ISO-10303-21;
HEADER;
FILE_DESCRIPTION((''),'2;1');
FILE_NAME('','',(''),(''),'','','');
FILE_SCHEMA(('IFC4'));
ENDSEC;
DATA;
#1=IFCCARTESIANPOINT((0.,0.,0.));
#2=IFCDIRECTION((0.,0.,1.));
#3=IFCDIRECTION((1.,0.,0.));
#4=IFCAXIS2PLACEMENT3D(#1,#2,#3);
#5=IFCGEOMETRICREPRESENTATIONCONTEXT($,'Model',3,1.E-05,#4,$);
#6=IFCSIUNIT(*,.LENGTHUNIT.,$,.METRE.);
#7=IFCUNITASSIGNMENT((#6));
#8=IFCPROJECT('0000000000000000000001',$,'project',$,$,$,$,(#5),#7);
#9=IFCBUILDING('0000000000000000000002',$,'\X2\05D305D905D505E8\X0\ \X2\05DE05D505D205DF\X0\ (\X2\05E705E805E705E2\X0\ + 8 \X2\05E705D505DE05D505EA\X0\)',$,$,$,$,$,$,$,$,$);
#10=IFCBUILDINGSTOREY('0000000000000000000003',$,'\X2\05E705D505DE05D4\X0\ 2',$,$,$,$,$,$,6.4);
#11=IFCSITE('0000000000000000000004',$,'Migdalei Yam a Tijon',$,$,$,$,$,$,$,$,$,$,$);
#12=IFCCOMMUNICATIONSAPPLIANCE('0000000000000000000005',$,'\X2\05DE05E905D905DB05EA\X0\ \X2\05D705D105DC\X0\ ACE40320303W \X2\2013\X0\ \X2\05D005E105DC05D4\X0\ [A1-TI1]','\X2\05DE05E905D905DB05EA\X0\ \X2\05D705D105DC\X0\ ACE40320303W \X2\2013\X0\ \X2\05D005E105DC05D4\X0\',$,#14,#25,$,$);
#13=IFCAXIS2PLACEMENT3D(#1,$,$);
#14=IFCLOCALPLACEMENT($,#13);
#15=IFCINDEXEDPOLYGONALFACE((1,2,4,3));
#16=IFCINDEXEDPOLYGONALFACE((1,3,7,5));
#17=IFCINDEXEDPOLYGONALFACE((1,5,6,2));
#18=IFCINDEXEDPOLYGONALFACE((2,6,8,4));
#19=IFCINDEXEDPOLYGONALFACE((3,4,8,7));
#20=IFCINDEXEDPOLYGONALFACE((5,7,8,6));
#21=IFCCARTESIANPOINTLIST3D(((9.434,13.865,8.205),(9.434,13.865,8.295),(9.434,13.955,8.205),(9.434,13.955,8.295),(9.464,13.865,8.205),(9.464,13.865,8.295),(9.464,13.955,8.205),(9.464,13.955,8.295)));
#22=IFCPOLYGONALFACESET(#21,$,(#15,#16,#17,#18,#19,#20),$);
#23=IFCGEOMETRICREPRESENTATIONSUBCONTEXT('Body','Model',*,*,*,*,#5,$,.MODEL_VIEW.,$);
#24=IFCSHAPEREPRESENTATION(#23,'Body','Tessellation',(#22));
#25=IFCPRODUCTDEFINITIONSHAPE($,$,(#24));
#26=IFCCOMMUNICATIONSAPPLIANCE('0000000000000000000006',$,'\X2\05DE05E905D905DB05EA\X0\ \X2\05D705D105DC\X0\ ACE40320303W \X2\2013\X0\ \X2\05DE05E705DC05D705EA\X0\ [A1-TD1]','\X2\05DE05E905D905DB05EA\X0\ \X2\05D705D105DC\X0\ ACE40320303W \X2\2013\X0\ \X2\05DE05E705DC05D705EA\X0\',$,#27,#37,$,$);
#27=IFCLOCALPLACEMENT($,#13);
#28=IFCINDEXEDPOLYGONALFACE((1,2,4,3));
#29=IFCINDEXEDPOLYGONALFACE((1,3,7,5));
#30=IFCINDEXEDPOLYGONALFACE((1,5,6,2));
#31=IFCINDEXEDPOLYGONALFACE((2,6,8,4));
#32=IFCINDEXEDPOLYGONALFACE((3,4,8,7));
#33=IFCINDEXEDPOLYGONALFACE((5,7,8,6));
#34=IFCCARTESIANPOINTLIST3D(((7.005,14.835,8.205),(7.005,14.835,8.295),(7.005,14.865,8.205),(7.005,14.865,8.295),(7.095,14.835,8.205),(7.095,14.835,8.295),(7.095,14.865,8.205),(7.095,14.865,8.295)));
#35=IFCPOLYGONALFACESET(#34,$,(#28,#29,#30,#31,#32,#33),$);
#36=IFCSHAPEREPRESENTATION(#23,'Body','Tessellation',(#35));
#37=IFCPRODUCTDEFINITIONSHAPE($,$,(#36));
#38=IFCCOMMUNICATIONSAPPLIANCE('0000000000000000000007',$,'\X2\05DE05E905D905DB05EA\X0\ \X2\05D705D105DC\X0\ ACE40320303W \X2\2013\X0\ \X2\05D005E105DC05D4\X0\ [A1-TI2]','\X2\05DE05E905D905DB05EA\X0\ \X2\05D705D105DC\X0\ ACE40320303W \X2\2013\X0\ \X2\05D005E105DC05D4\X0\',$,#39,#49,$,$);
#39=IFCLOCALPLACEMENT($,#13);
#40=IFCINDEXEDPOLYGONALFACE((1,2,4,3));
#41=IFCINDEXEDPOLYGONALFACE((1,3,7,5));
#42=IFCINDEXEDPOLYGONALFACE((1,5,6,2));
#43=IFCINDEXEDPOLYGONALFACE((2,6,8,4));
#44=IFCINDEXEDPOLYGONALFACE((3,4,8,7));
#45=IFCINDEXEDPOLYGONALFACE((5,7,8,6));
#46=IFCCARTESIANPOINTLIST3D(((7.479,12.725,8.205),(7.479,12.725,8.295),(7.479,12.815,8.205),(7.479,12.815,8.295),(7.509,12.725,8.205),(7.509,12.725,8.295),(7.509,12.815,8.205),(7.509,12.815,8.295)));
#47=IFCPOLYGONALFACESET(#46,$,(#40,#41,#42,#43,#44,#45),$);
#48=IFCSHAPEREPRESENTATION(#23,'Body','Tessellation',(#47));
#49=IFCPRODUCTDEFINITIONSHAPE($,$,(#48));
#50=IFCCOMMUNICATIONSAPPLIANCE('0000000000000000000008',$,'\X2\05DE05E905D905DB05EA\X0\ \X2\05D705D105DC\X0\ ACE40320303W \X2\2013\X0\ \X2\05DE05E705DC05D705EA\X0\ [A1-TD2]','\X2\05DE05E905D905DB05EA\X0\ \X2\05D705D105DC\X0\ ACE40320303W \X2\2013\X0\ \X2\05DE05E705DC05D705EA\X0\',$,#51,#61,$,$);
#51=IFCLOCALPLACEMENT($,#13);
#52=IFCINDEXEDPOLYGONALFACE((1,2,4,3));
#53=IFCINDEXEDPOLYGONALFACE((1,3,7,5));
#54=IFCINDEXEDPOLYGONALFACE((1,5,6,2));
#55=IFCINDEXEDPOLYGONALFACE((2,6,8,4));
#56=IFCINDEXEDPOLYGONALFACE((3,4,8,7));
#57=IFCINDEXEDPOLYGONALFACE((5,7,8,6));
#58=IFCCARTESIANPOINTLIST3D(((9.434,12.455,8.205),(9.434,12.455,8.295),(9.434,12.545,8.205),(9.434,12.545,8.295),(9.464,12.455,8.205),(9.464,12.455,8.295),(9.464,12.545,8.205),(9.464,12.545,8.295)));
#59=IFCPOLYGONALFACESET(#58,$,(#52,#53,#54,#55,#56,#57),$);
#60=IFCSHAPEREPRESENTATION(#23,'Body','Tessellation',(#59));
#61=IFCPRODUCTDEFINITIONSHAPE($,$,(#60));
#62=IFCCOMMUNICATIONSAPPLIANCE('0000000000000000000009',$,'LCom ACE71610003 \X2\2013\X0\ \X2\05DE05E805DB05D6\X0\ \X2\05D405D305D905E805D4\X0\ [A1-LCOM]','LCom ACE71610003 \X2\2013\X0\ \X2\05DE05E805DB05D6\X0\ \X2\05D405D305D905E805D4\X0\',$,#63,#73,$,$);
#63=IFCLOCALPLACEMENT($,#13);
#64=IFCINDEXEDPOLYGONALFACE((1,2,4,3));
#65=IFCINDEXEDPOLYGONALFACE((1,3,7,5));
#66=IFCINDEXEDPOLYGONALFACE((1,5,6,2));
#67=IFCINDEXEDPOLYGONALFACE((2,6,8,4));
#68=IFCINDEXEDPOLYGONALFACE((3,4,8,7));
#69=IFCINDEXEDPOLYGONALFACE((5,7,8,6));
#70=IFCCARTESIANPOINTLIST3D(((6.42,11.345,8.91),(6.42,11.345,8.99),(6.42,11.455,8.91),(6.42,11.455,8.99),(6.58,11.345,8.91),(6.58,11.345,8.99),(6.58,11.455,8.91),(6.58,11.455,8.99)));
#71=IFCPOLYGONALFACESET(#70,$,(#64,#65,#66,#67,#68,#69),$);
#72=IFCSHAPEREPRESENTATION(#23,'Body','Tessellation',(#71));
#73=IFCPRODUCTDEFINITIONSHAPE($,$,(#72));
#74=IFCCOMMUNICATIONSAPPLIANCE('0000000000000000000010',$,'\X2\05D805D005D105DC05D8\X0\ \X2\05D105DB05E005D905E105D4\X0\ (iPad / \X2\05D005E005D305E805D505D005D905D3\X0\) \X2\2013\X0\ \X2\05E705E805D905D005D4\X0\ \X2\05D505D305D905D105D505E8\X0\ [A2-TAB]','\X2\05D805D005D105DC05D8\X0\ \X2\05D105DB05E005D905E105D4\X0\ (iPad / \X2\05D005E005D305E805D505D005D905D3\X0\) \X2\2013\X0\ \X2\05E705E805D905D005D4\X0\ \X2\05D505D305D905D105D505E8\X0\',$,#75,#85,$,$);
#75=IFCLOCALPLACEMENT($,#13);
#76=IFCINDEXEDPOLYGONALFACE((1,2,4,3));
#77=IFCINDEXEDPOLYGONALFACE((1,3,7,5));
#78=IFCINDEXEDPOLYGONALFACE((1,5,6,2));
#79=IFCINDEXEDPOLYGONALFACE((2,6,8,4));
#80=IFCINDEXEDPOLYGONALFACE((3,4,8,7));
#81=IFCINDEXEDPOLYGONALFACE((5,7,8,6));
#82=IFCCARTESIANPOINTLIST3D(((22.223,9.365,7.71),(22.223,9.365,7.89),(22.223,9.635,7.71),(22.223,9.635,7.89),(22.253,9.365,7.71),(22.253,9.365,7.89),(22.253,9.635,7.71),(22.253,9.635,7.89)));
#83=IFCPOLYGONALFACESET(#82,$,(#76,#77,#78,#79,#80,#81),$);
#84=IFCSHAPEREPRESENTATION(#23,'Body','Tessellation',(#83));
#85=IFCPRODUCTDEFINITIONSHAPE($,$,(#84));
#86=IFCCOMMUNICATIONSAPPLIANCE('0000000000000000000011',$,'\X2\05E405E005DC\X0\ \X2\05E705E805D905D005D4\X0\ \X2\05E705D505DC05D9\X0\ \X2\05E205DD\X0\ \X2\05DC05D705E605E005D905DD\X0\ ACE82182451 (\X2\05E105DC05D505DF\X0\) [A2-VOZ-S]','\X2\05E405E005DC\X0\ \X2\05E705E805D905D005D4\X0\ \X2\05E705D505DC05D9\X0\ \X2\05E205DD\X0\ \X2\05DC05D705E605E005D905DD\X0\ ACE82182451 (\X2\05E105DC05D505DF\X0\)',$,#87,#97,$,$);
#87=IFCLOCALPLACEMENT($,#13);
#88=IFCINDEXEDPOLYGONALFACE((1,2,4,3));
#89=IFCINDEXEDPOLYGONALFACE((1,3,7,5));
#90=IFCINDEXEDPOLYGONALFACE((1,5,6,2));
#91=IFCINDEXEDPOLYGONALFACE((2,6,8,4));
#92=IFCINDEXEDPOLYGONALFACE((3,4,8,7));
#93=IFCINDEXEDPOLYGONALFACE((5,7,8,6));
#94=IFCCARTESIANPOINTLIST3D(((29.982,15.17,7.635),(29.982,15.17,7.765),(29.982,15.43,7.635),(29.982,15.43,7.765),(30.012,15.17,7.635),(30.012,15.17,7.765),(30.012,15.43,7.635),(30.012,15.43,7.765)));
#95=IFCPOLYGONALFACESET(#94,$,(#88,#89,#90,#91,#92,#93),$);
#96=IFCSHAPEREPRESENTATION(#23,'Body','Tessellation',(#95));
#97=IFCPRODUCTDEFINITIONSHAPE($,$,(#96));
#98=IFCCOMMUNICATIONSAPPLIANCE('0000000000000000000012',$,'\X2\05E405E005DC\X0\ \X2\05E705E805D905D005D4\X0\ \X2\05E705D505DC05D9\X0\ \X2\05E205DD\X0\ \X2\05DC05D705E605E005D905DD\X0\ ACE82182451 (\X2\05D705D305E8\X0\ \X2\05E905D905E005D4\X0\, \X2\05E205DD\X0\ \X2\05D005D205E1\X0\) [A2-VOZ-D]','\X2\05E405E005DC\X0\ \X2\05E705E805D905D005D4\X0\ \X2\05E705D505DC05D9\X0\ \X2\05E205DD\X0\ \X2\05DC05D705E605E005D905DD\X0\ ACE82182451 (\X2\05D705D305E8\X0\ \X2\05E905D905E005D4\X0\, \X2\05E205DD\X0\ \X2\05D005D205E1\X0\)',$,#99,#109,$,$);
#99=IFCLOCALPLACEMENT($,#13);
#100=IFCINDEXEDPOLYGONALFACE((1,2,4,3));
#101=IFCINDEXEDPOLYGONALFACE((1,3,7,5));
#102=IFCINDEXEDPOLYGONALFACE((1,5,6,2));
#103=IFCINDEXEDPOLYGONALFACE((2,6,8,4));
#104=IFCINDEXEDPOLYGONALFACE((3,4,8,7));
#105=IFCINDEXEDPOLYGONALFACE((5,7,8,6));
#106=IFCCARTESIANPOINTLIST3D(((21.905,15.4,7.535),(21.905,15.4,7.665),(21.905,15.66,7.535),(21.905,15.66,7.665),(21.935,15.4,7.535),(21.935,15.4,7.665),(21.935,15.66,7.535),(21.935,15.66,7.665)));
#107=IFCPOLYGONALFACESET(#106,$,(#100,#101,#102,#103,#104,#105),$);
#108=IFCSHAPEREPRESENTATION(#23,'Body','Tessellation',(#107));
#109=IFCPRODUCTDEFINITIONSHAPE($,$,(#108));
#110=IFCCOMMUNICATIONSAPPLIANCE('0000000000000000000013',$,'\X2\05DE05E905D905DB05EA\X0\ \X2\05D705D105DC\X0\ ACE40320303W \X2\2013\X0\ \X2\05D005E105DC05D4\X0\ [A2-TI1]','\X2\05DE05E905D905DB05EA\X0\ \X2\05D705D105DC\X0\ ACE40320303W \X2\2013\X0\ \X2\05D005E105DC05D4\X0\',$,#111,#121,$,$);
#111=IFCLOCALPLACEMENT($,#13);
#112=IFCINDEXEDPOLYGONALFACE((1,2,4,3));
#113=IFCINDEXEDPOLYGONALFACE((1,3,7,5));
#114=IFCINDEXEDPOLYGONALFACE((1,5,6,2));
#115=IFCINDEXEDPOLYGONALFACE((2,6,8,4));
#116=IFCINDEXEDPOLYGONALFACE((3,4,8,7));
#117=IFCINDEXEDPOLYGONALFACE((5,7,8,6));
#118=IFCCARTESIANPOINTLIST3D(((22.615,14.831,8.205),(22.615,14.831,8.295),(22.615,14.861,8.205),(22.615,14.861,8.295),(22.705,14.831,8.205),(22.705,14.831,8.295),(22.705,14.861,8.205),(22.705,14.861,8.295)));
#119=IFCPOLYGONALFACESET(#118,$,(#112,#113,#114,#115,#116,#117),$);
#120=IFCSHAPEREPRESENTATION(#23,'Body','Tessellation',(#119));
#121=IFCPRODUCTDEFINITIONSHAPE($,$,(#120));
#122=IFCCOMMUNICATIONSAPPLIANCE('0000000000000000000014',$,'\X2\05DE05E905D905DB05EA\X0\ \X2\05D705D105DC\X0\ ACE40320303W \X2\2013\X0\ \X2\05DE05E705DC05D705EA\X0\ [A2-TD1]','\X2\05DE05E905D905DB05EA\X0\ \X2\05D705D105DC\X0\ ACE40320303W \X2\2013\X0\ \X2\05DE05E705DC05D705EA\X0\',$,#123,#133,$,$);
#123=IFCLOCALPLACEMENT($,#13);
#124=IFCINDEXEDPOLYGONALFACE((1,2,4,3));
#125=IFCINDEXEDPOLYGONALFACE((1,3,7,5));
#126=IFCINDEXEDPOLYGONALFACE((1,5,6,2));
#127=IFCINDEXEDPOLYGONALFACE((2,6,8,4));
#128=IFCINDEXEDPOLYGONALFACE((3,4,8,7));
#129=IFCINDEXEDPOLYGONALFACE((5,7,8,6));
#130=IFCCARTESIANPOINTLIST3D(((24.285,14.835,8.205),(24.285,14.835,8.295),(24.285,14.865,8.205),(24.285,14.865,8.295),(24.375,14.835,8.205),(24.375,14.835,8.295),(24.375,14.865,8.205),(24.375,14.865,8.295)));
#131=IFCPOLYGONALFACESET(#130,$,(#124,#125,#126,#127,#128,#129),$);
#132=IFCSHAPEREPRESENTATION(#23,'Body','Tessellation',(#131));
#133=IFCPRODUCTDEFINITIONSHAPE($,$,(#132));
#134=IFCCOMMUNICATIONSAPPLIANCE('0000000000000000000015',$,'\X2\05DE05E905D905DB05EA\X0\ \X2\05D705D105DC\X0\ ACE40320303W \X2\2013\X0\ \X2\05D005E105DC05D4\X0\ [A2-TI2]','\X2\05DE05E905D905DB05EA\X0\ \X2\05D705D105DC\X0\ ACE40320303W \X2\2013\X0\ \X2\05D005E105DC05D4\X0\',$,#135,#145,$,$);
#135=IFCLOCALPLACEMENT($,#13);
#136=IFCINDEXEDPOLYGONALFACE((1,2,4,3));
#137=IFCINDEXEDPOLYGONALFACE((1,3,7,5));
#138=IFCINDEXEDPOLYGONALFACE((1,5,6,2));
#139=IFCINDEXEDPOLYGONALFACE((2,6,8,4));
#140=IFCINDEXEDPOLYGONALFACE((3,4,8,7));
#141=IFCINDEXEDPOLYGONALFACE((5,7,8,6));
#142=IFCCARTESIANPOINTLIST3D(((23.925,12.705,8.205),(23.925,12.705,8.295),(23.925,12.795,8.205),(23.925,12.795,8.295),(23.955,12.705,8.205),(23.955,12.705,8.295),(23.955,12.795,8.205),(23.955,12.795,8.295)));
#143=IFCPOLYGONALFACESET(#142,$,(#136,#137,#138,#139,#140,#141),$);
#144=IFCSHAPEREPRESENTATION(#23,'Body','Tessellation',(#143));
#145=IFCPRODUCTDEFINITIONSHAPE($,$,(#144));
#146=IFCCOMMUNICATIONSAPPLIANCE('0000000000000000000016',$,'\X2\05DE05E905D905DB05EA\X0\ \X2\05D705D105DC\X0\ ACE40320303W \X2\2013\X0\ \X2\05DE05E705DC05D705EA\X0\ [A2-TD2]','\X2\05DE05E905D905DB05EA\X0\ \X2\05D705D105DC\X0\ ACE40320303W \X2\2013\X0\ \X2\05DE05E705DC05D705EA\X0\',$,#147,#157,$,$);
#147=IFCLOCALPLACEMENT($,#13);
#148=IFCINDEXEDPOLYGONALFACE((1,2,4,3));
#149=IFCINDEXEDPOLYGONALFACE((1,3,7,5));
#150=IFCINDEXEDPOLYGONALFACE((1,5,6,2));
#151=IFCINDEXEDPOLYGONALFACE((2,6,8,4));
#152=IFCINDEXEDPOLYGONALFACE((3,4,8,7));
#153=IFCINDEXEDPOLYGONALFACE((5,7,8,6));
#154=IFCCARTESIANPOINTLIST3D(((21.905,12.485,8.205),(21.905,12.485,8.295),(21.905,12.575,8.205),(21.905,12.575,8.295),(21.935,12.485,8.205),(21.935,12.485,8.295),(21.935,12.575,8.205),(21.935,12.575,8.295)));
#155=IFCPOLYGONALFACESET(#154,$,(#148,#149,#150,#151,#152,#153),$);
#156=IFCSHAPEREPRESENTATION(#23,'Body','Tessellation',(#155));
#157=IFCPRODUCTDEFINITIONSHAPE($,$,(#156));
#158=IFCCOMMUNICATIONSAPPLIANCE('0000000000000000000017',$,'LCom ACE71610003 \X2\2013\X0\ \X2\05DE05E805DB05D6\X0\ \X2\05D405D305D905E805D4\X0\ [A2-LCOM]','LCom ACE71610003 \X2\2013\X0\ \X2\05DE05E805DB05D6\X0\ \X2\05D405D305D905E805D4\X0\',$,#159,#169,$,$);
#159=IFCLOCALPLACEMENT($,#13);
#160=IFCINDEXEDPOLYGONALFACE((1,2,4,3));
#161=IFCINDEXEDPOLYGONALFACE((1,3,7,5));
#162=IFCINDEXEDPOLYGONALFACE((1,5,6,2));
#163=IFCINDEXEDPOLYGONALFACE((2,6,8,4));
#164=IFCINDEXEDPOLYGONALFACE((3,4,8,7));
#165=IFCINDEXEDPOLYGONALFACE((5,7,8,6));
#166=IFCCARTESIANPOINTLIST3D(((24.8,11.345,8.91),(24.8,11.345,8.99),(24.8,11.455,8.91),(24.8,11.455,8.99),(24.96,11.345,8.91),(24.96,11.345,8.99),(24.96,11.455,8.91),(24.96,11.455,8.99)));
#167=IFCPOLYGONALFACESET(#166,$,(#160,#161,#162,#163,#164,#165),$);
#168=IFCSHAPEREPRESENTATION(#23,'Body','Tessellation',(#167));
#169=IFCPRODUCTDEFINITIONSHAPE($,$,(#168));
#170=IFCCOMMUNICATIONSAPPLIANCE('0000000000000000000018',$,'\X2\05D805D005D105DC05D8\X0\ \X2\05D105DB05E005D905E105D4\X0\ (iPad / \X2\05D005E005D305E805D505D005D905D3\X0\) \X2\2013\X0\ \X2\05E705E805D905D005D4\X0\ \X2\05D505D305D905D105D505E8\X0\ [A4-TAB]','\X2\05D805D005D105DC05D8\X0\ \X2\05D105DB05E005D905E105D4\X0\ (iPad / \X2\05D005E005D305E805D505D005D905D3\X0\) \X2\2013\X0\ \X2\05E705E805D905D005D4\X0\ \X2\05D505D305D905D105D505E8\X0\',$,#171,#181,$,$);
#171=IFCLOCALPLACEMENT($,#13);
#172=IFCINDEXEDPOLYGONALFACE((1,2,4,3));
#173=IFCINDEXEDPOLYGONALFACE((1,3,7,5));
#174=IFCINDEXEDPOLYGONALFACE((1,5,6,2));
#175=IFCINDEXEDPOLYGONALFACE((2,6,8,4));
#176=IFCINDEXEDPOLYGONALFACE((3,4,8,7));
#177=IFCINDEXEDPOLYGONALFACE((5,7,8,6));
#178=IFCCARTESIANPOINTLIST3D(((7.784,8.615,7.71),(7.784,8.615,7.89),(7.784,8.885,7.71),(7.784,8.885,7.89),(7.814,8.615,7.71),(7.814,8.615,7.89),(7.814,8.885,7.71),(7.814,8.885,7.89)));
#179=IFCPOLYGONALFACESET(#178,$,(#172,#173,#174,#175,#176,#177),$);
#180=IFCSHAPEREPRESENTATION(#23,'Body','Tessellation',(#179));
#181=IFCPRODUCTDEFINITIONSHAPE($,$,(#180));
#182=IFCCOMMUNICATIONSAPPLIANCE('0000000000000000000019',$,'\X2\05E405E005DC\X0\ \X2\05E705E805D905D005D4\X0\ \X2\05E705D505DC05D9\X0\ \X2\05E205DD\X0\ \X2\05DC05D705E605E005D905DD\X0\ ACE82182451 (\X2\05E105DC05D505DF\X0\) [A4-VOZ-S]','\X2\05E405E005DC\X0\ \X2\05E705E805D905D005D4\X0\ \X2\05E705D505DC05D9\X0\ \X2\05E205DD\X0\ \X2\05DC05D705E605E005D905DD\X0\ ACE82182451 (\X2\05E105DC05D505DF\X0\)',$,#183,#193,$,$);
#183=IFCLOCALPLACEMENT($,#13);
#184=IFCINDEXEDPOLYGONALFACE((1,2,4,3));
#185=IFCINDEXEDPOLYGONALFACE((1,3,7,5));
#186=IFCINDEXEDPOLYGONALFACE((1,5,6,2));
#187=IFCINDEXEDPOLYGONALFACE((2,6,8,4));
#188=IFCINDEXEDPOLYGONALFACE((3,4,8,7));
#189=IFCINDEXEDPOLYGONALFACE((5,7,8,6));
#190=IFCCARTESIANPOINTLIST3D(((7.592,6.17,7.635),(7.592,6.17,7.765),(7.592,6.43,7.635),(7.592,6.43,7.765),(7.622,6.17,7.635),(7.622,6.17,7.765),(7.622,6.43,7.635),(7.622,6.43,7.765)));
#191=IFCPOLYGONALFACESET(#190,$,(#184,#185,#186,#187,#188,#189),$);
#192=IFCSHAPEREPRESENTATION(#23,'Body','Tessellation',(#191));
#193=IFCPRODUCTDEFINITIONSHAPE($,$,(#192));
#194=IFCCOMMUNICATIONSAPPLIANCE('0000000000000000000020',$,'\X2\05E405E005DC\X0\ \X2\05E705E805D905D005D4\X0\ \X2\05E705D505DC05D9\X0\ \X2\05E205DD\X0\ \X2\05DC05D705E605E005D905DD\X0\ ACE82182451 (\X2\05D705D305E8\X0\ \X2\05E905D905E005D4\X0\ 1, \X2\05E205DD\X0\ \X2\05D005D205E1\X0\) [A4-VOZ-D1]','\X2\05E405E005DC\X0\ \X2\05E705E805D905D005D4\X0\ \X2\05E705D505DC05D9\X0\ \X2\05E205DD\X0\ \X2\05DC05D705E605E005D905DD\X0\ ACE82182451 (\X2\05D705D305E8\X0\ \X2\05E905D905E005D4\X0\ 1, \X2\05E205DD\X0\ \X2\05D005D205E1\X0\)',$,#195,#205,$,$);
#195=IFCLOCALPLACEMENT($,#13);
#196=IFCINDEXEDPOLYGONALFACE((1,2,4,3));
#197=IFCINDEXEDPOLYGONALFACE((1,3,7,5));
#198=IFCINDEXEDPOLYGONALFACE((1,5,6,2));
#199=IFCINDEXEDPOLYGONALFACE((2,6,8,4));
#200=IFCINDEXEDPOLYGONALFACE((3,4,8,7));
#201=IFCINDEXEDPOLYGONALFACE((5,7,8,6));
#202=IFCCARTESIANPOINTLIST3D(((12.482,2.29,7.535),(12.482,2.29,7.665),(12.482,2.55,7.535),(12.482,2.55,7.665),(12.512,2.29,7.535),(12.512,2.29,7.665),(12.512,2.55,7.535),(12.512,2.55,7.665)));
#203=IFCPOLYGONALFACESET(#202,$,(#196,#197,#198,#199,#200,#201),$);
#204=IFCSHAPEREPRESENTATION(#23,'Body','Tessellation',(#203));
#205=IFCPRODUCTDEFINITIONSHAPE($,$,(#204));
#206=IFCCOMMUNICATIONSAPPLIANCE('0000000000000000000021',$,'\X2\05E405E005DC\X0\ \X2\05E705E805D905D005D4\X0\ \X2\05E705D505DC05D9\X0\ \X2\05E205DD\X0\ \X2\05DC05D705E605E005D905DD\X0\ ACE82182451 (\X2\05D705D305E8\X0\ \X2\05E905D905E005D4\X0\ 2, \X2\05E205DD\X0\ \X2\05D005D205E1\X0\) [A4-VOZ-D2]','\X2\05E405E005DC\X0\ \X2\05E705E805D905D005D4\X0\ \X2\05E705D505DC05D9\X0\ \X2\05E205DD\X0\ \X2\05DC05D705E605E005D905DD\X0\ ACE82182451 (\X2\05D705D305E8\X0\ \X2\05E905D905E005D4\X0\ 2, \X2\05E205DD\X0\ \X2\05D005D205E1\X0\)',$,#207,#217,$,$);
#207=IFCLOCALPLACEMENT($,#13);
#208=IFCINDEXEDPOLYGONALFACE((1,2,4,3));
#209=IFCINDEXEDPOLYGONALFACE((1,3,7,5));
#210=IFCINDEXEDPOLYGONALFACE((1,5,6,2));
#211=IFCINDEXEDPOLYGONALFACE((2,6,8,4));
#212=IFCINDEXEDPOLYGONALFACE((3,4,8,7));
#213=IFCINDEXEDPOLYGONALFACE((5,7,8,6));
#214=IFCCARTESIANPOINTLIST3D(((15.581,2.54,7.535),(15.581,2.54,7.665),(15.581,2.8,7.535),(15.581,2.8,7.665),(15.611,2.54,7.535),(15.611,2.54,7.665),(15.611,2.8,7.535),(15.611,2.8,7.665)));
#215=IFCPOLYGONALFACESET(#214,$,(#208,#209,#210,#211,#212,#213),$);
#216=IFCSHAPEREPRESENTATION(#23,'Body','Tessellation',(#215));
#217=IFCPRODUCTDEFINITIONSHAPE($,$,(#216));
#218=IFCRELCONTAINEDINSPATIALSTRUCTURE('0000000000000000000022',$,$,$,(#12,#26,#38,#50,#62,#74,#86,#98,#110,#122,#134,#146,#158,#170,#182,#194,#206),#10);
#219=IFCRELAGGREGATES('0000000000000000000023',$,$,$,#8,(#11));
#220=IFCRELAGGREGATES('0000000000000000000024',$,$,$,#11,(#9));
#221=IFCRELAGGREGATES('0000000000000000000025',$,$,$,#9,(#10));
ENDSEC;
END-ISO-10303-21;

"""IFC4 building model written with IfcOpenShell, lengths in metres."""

from ifc_helpers import new_model, si_unit, frame, origin_with_axes, context, subcontext, project, spatial, line, indexed_curve, outline, extrude, element, save


model = new_model("IFC4")

# Units and contexts
model_context = context("Model", 3, precision=1e-05, world=origin_with_axes())
body_context = subcontext(model_context, "Body", "Model", "MODEL_VIEW")
ifc_project = project(units=[si_unit("LENGTHUNIT", "METRE")], contexts=[model_context])

# Site, building, storey
site = spatial("IfcSite", under=ifc_project, Name="Migdalei Yam a Tijon")
building = spatial("IfcBuilding", under=site, Name="דיור מוגן (קרקע + 8 קומות)")
storey = spatial("IfcBuildingStorey", under=building, Name="קומה 2", Elevation=6.4)

# Communications appliances
element("IfcCommunicationsAppliance", 1, inside=storey, Name="משיכת חבל ACE40320303W – אסלה [A1-TI1]", Description="משיכת חבל ACE40320303W – אסלה", context=body_context, shape_type="SweptSolid", body=[
    extrude(outline(indexed_curve([(0.0, 0.0), (0.03, 0.0), (0.03, 0.09), (0.0, 0.09)], segments=[line(1, 2, 3, 4, 1)])), frame((9.434, 13.865, 8.205), z_axis=(0.0, 0.0, 1.0), x_axis=(1.0, 0.0, 0.0)), (0.0, 0.0, 1.0), 0.09),
])
element("IfcCommunicationsAppliance", 2, inside=storey, Name="משיכת חבל ACE40320303W – מקלחת [A1-TD1]", Description="משיכת חבל ACE40320303W – מקלחת", context=body_context, shape_type="SweptSolid", body=[
    extrude(outline(indexed_curve([(0.0, 0.0), (0.09, 0.0), (0.09, 0.03), (0.0, 0.03)], segments=[line(1, 2, 3, 4, 1)])), frame((7.005, 14.835, 8.205), z_axis=(0.0, 0.0, 1.0), x_axis=(1.0, 0.0, 0.0)), (0.0, 0.0, 1.0), 0.09),
])
element("IfcCommunicationsAppliance", 3, inside=storey, Name="משיכת חבל ACE40320303W – אסלה [A1-TI2]", Description="משיכת חבל ACE40320303W – אסלה", context=body_context, shape_type="SweptSolid", body=[
    extrude(outline(indexed_curve([(0.0, 0.0), (0.03, 0.0), (0.03, 0.09), (0.0, 0.09)], segments=[line(1, 2, 3, 4, 1)])), frame((7.479, 12.725, 8.205), z_axis=(0.0, 0.0, 1.0), x_axis=(1.0, 0.0, 0.0)), (0.0, 0.0, 1.0), 0.09),
])
element("IfcCommunicationsAppliance", 4, inside=storey, Name="משיכת חבל ACE40320303W – מקלחת [A1-TD2]", Description="משיכת חבל ACE40320303W – מקלחת", context=body_context, shape_type="SweptSolid", body=[
    extrude(outline(indexed_curve([(0.0, 0.0), (0.03, 0.0), (0.03, 0.09), (0.0, 0.09)], segments=[line(1, 2, 3, 4, 1)])), frame((9.434, 12.455, 8.205), z_axis=(0.0, 0.0, 1.0), x_axis=(1.0, 0.0, 0.0)), (0.0, 0.0, 1.0), 0.09),
])
element("IfcCommunicationsAppliance", 5, inside=storey, Name="LCom ACE71610003 – מרכז הדירה [A1-LCOM]", Description="LCom ACE71610003 – מרכז הדירה", context=body_context, shape_type="SweptSolid", body=[
    extrude(outline(indexed_curve([(0.0, 0.0), (0.16, 0.0), (0.16, 0.11), (0.0, 0.11)], segments=[line(1, 2, 3, 4, 1)])), frame((6.42, 11.345, 8.91), z_axis=(0.0, 0.0, 1.0), x_axis=(1.0, 0.0, 0.0)), (0.0, 0.0, 1.0), 0.08),
])
element("IfcCommunicationsAppliance", 6, inside=storey, Name="טאבלט בכניסה (iPad / אנדרואיד) – קריאה ודיבור [A2-TAB]", Description="טאבלט בכניסה (iPad / אנדרואיד) – קריאה ודיבור", context=body_context, shape_type="SweptSolid", body=[
    extrude(outline(indexed_curve([(0.0, 0.0), (0.03, 0.0), (0.03, 0.27), (0.0, 0.27)], segments=[line(1, 2, 3, 4, 1)])), frame((22.223, 9.365, 7.71), z_axis=(0.0, 0.0, 1.0), x_axis=(1.0, 0.0, 0.0)), (0.0, 0.0, 1.0), 0.18),
])
element("IfcCommunicationsAppliance", 7, inside=storey, Name="פנל קריאה קולי עם לחצנים ACE82182451 (סלון) [A2-VOZ-S]", Description="פנל קריאה קולי עם לחצנים ACE82182451 (סלון)", context=body_context, shape_type="SweptSolid", body=[
    extrude(outline(indexed_curve([(0.0, 0.0), (0.03, 0.0), (0.03, 0.26), (0.0, 0.26)], segments=[line(1, 2, 3, 4, 1)])), frame((29.982, 15.17, 7.635), z_axis=(0.0, 0.0, 1.0), x_axis=(1.0, 0.0, 0.0)), (0.0, 0.0, 1.0), 0.13),
])
element("IfcCommunicationsAppliance", 8, inside=storey, Name="פנל קריאה קולי עם לחצנים ACE82182451 (חדר שינה, עם אגס) [A2-VOZ-D]", Description="פנל קריאה קולי עם לחצנים ACE82182451 (חדר שינה, עם אגס)", context=body_context, shape_type="SweptSolid", body=[
    extrude(outline(indexed_curve([(0.0, 0.0), (0.03, 0.0), (0.03, 0.26), (0.0, 0.26)], segments=[line(1, 2, 3, 4, 1)])), frame((21.905, 15.4, 7.535), z_axis=(0.0, 0.0, 1.0), x_axis=(1.0, 0.0, 0.0)), (0.0, 0.0, 1.0), 0.13),
])
element("IfcCommunicationsAppliance", 9, inside=storey, Name="משיכת חבל ACE40320303W – אסלה [A2-TI1]", Description="משיכת חבל ACE40320303W – אסלה", context=body_context, shape_type="SweptSolid", body=[
    extrude(outline(indexed_curve([(0.0, 0.0), (0.09, 0.0), (0.09, 0.03), (0.0, 0.03)], segments=[line(1, 2, 3, 4, 1)])), frame((22.615, 14.831, 8.205), z_axis=(0.0, 0.0, 1.0), x_axis=(1.0, 0.0, 0.0)), (0.0, 0.0, 1.0), 0.09),
])
element("IfcCommunicationsAppliance", 10, inside=storey, Name="משיכת חבל ACE40320303W – מקלחת [A2-TD1]", Description="משיכת חבל ACE40320303W – מקלחת", context=body_context, shape_type="SweptSolid", body=[
    extrude(outline(indexed_curve([(0.0, 0.0), (0.09, 0.0), (0.09, 0.03), (0.0, 0.03)], segments=[line(1, 2, 3, 4, 1)])), frame((24.285, 14.835, 8.205), z_axis=(0.0, 0.0, 1.0), x_axis=(1.0, 0.0, 0.0)), (0.0, 0.0, 1.0), 0.09),
])
element("IfcCommunicationsAppliance", 11, inside=storey, Name="משיכת חבל ACE40320303W – אסלה [A2-TI2]", Description="משיכת חבל ACE40320303W – אסלה", context=body_context, shape_type="SweptSolid", body=[
    extrude(outline(indexed_curve([(0.0, 0.0), (0.03, 0.0), (0.03, 0.09), (0.0, 0.09)], segments=[line(1, 2, 3, 4, 1)])), frame((23.925, 12.705, 8.205), z_axis=(0.0, 0.0, 1.0), x_axis=(1.0, 0.0, 0.0)), (0.0, 0.0, 1.0), 0.09),
])
element("IfcCommunicationsAppliance", 12, inside=storey, Name="משיכת חבל ACE40320303W – מקלחת [A2-TD2]", Description="משיכת חבל ACE40320303W – מקלחת", context=body_context, shape_type="SweptSolid", body=[
    extrude(outline(indexed_curve([(0.0, 0.0), (0.03, 0.0), (0.03, 0.09), (0.0, 0.09)], segments=[line(1, 2, 3, 4, 1)])), frame((21.905, 12.485, 8.205), z_axis=(0.0, 0.0, 1.0), x_axis=(1.0, 0.0, 0.0)), (0.0, 0.0, 1.0), 0.09),
])
element("IfcCommunicationsAppliance", 13, inside=storey, Name="LCom ACE71610003 – מרכז הדירה [A2-LCOM]", Description="LCom ACE71610003 – מרכז הדירה", context=body_context, shape_type="SweptSolid", body=[
    extrude(outline(indexed_curve([(0.0, 0.0), (0.16, 0.0), (0.16, 0.11), (0.0, 0.11)], segments=[line(1, 2, 3, 4, 1)])), frame((24.8, 11.345, 8.91), z_axis=(0.0, 0.0, 1.0), x_axis=(1.0, 0.0, 0.0)), (0.0, 0.0, 1.0), 0.08),
])
element("IfcCommunicationsAppliance", 14, inside=storey, Name="טאבלט בכניסה (iPad / אנדרואיד) – קריאה ודיבור [A4-TAB]", Description="טאבלט בכניסה (iPad / אנדרואיד) – קריאה ודיבור", context=body_context, shape_type="SweptSolid", body=[
    extrude(outline(indexed_curve([(0.0, 0.0), (0.03, 0.0), (0.03, 0.27), (0.0, 0.27)], segments=[line(1, 2, 3, 4, 1)])), frame((7.784, 8.615, 7.71), z_axis=(0.0, 0.0, 1.0), x_axis=(1.0, 0.0, 0.0)), (0.0, 0.0, 1.0), 0.18),
])
element("IfcCommunicationsAppliance", 15, inside=storey, Name="פנל קריאה קולי עם לחצנים ACE82182451 (סלון) [A4-VOZ-S]", Description="פנל קריאה קולי עם לחצנים ACE82182451 (סלון)", context=body_context, shape_type="SweptSolid", body=[
    extrude(outline(indexed_curve([(0.0, 0.0), (0.03, 0.0), (0.03, 0.26), (0.0, 0.26)], segments=[line(1, 2, 3, 4, 1)])), frame((7.592, 6.17, 7.635), z_axis=(0.0, 0.0, 1.0), x_axis=(1.0, 0.0, 0.0)), (0.0, 0.0, 1.0), 0.13),
])
element("IfcCommunicationsAppliance", 16, inside=storey, Name="פנל קריאה קולי עם לחצנים ACE82182451 (חדר שינה 1, עם אגס) [A4-VOZ-D1]", Description="פנל קריאה קולי עם לחצנים ACE82182451 (חדר שינה 1, עם אגס)", context=body_context, shape_type="SweptSolid", body=[
    extrude(outline(indexed_curve([(0.0, 0.0), (0.03, 0.0), (0.03, 0.26), (0.0, 0.26)], segments=[line(1, 2, 3, 4, 1)])), frame((12.482, 2.29, 7.535), z_axis=(0.0, 0.0, 1.0), x_axis=(1.0, 0.0, 0.0)), (0.0, 0.0, 1.0), 0.13),
])
element("IfcCommunicationsAppliance", 17, inside=storey, Name="פנל קריאה קולי עם לחצנים ACE82182451 (חדר שינה 2, עם אגס) [A4-VOZ-D2]", Description="פנל קריאה קולי עם לחצנים ACE82182451 (חדר שינה 2, עם אגס)", context=body_context, shape_type="SweptSolid", body=[
    extrude(outline(indexed_curve([(0.0, 0.0), (0.03, 0.0), (0.03, 0.26), (0.0, 0.26)], segments=[line(1, 2, 3, 4, 1)])), frame((15.581, 2.54, 7.535), z_axis=(0.0, 0.0, 1.0), x_axis=(1.0, 0.0, 0.0)), (0.0, 0.0, 1.0), 0.13),
])

save(model, "model.ifc")
